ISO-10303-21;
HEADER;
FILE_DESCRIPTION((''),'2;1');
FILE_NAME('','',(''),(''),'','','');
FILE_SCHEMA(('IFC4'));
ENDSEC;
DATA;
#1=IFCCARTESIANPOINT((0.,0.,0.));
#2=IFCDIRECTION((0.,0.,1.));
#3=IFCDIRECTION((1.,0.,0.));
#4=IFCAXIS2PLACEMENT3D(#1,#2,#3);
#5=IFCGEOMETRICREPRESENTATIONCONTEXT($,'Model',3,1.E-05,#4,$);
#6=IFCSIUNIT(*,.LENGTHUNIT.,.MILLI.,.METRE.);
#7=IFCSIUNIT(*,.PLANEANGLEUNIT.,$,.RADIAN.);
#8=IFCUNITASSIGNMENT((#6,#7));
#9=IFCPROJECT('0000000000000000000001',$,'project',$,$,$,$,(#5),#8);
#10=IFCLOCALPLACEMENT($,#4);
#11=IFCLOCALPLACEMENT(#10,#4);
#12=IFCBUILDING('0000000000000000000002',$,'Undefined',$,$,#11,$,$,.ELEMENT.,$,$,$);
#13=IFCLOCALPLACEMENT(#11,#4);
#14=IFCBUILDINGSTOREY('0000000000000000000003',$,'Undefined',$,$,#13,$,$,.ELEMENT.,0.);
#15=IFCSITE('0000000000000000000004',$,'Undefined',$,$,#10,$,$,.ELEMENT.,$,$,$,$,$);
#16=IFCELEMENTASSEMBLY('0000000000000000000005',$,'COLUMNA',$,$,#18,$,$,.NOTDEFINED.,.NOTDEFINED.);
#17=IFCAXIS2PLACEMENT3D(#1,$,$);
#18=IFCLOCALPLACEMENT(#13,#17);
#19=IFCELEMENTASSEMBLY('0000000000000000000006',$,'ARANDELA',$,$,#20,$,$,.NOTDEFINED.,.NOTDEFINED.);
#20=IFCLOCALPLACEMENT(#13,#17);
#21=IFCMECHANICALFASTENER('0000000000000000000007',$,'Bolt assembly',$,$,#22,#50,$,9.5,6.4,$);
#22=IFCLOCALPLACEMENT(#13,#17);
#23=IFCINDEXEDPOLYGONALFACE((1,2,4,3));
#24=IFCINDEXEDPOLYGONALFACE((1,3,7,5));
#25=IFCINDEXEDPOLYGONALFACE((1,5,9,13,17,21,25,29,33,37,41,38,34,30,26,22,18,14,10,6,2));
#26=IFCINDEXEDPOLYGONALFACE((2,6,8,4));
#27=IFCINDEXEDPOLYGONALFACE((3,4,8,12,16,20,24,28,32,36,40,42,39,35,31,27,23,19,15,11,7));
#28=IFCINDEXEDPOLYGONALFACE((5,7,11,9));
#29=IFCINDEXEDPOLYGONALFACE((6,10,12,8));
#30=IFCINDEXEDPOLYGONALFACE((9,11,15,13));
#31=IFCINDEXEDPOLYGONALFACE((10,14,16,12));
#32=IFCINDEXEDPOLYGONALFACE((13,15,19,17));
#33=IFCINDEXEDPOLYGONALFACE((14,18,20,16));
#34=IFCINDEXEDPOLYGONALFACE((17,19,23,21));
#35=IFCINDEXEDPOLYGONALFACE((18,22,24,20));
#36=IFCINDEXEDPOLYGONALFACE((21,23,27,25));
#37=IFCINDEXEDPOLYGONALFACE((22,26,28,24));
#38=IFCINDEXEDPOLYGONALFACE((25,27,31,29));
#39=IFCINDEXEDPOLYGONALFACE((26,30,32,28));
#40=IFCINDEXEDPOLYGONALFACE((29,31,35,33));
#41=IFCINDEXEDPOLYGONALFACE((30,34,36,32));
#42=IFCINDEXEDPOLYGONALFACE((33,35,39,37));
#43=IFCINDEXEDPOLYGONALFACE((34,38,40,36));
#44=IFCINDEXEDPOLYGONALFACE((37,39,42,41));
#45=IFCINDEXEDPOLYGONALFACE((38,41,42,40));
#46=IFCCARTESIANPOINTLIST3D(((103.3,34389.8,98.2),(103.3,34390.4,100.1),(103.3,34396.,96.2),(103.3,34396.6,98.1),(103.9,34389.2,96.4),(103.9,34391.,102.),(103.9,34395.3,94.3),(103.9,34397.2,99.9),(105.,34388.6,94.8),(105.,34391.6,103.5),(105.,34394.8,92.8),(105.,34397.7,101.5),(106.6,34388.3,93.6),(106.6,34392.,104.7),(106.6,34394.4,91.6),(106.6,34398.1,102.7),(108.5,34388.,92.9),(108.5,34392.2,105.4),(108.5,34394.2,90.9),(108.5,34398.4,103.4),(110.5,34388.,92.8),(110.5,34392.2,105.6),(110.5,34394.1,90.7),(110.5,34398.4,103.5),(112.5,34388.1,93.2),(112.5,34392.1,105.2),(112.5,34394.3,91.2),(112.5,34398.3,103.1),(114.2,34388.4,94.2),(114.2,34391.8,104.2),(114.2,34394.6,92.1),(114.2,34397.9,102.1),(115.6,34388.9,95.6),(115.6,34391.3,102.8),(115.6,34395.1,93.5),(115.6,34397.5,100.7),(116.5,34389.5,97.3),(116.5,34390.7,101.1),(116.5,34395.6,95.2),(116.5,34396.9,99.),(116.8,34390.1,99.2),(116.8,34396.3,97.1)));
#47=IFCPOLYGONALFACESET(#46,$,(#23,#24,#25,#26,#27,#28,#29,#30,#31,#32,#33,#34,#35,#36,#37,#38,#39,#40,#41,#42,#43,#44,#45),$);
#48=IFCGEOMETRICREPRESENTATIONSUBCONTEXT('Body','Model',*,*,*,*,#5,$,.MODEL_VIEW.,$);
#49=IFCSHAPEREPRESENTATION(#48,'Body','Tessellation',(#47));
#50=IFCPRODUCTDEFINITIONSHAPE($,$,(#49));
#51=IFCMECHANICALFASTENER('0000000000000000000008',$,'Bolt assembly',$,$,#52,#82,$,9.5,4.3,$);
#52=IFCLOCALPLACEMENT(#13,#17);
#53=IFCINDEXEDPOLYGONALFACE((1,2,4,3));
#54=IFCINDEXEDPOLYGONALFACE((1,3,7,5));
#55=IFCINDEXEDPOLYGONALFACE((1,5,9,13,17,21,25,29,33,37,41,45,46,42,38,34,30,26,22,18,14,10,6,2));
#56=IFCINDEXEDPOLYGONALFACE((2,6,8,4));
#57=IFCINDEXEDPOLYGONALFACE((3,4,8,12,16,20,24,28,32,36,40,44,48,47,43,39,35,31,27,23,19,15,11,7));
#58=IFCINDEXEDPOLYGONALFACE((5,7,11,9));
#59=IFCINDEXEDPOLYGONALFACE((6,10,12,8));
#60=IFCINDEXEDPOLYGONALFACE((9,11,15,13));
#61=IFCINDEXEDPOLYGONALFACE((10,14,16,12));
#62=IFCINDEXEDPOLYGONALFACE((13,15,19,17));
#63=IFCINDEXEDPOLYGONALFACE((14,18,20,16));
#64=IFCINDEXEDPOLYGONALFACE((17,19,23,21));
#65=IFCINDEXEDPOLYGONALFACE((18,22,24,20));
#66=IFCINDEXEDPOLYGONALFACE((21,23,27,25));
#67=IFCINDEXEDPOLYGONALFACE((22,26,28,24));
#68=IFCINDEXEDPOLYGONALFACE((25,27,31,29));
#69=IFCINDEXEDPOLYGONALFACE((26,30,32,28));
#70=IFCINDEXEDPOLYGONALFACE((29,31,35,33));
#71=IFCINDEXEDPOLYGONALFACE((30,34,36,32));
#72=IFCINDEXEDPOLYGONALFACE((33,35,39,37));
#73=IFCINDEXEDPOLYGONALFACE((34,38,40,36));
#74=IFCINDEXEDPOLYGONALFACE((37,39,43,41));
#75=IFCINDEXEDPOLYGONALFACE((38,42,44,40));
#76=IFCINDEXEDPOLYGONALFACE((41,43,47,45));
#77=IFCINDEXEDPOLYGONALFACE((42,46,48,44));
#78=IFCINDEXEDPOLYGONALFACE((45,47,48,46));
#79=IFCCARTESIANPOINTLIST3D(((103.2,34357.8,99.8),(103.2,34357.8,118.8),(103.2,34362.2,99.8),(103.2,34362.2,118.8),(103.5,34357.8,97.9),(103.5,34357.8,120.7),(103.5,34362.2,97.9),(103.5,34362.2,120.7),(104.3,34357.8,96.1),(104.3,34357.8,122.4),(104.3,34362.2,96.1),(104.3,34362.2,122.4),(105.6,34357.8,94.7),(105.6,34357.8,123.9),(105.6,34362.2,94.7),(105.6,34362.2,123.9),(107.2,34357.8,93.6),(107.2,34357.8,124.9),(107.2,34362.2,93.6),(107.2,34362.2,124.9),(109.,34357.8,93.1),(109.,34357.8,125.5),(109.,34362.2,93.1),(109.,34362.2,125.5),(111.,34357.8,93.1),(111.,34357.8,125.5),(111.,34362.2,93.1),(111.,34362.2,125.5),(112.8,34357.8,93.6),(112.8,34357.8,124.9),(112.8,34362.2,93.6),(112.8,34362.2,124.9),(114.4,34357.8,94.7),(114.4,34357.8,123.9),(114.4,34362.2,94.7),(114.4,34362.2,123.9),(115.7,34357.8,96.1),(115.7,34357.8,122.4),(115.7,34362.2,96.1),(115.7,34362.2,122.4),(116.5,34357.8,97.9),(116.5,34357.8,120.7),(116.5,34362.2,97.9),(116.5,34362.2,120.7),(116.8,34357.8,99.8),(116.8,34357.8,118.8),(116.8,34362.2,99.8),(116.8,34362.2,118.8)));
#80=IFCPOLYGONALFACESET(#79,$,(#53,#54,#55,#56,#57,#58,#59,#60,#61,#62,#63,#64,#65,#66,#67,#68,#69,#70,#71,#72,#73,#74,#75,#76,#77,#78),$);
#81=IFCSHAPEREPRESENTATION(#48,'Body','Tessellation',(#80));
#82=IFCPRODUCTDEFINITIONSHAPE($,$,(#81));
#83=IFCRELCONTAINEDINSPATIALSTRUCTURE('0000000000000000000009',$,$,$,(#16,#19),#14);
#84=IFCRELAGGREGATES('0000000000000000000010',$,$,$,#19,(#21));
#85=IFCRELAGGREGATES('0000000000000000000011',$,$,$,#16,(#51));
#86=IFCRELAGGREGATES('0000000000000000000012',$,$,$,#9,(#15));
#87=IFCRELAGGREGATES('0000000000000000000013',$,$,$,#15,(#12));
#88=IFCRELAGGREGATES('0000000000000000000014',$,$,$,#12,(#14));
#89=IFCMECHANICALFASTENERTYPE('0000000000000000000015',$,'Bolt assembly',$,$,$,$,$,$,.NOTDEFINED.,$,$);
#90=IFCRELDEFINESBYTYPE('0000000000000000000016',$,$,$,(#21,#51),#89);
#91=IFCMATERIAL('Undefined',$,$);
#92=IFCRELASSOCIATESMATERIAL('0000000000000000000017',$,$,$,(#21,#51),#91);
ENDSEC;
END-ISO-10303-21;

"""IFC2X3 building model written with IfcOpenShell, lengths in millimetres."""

from ifc_helpers import new_model, si_unit, frame, frame_2d, origin_with_axes, origin_2d_with_axis, place, context, subcontext, project, spatial, polyline, circle_curve, parameter, trimmed, segment, composite_curve, circle, outline, extrude, source, transform, mapped, material, type_object, element, aggregate, save


model = new_model("IFC2X3")

# Units and contexts
model_context = context("Model", 3, precision=1e-05, world=origin_with_axes())
body_context = subcontext(model_context, "Body", "Model", "MODEL_VIEW")
ifc_project = project(units=[si_unit("LENGTHUNIT", "METRE", prefix="MILLI"), si_unit("PLANEANGLEUNIT", "RADIAN")], contexts=[model_context])

# Site, building, storey
site_placement = place(None, origin_with_axes())
site = spatial("IfcSite", under=ifc_project, at=site_placement, Name="Undefined", CompositionType="ELEMENT")
building_placement = place(site_placement, origin_with_axes())
building = spatial("IfcBuilding", under=site, at=building_placement, Name="Undefined", CompositionType="ELEMENT")
storey_placement = place(building_placement, origin_with_axes())
storey = spatial("IfcBuildingStorey", under=building, at=storey_placement, Name="Undefined", CompositionType="ELEMENT", Elevation=0.0)

# Element assembly
assembly_1_placement = place(storey_placement, origin_with_axes())
assembly_1 = element("IfcElementAssembly", 1, at=assembly_1_placement, inside=storey, Name="COLUMNA", AssemblyPlace="NOTDEFINED", PredefinedType="NOTDEFINED")

# Element assembly
assembly_2_placement = place(storey_placement, origin_with_axes())
assembly_2 = element("IfcElementAssembly", 2, at=assembly_2_placement, inside=storey, Name="ARANDELA", AssemblyPlace="NOTDEFINED", PredefinedType="NOTDEFINED")

# Mechanical fasteners
ifc_material_1 = material(Name="Undefined")
mechanical_fastener_type = type_object("IfcMechanicalFastenerType", Name="Bolt assembly")
shared_shape_1 = source(origin_with_axes(), body_context, "Body", "SweptSolid", [
    extrude(circle(Radius=6.8, at=origin_2d_with_axis()), frame((0.0, -6.4, 0.0), z_axis=(0.0, 1.0, 0.0), x_axis=(1.0, 0.0, 0.0)), (0.0, 0.0, 1.0), 6.5),
])
mechanical_fastener_1_placement = place(assembly_2_placement, frame((110.0, 34390.2, 99.2), z_axis=(0.0, -0.317285, -0.94833), x_axis=(1.0, 0.0, 0.0)))
mechanical_fastener_1 = element("IfcMechanicalFastener", 3, at=mechanical_fastener_1_placement, type_object=mechanical_fastener_type, material=ifc_material_1, Name="Bolt assembly", NominalDiameter=9.5, NominalLength=6.4, context=body_context, shape_type="MappedRepresentation", body=[
    mapped(shared_shape_1, transform((0.0, 0.0, 0.0))),
])
aggregate(assembly_2, [mechanical_fastener_1])
shared_shape_2 = source(origin_with_axes(), body_context, "Body", "SweptSolid", [
    extrude(outline(composite_curve([segment(polyline([(-9.5, 6.8), (9.5, 6.8)]), True, "CONTINUOUS"), segment(trimmed(circle_curve(frame_2d((9.5, 0.0), x_axis=(0.0, 1.0)), 6.8), [parameter(0.0)], [parameter(3.141593)], False, "PARAMETER"), True, "CONTINUOUS"), segment(polyline([(9.5, -6.8), (-9.5, -6.8)]), True, "CONTINUOUS"), segment(trimmed(circle_curve(frame_2d((-9.5, 0.0), x_axis=(0.0, -1.0)), 6.8), [parameter(0.0)], [parameter(3.141593)], False, "PARAMETER"), True, "DISCONTINUOUS")], self_intersect=False)), frame((0.0, -4.3, 0.0), z_axis=(0.0, 1.0, 0.0), x_axis=(1.0, 0.0, 0.0)), (0.0, 0.0, 1.0), 4.4),
])
mechanical_fastener_2_placement = place(assembly_1_placement, frame((110.0, 34362.2, 109.3), z_axis=(-1.0, 0.0, 0.0), x_axis=(0.0, 0.0, 1.0)))
mechanical_fastener_2 = element("IfcMechanicalFastener", 4, at=mechanical_fastener_2_placement, type_object=mechanical_fastener_type, material=ifc_material_1, Name="Bolt assembly", NominalDiameter=9.5, NominalLength=4.3, context=body_context, shape_type="MappedRepresentation", body=[
    mapped(shared_shape_2, transform((0.0, 0.0, 0.0))),
])
aggregate(assembly_1, [mechanical_fastener_2])

save(model, "model.ifc")
